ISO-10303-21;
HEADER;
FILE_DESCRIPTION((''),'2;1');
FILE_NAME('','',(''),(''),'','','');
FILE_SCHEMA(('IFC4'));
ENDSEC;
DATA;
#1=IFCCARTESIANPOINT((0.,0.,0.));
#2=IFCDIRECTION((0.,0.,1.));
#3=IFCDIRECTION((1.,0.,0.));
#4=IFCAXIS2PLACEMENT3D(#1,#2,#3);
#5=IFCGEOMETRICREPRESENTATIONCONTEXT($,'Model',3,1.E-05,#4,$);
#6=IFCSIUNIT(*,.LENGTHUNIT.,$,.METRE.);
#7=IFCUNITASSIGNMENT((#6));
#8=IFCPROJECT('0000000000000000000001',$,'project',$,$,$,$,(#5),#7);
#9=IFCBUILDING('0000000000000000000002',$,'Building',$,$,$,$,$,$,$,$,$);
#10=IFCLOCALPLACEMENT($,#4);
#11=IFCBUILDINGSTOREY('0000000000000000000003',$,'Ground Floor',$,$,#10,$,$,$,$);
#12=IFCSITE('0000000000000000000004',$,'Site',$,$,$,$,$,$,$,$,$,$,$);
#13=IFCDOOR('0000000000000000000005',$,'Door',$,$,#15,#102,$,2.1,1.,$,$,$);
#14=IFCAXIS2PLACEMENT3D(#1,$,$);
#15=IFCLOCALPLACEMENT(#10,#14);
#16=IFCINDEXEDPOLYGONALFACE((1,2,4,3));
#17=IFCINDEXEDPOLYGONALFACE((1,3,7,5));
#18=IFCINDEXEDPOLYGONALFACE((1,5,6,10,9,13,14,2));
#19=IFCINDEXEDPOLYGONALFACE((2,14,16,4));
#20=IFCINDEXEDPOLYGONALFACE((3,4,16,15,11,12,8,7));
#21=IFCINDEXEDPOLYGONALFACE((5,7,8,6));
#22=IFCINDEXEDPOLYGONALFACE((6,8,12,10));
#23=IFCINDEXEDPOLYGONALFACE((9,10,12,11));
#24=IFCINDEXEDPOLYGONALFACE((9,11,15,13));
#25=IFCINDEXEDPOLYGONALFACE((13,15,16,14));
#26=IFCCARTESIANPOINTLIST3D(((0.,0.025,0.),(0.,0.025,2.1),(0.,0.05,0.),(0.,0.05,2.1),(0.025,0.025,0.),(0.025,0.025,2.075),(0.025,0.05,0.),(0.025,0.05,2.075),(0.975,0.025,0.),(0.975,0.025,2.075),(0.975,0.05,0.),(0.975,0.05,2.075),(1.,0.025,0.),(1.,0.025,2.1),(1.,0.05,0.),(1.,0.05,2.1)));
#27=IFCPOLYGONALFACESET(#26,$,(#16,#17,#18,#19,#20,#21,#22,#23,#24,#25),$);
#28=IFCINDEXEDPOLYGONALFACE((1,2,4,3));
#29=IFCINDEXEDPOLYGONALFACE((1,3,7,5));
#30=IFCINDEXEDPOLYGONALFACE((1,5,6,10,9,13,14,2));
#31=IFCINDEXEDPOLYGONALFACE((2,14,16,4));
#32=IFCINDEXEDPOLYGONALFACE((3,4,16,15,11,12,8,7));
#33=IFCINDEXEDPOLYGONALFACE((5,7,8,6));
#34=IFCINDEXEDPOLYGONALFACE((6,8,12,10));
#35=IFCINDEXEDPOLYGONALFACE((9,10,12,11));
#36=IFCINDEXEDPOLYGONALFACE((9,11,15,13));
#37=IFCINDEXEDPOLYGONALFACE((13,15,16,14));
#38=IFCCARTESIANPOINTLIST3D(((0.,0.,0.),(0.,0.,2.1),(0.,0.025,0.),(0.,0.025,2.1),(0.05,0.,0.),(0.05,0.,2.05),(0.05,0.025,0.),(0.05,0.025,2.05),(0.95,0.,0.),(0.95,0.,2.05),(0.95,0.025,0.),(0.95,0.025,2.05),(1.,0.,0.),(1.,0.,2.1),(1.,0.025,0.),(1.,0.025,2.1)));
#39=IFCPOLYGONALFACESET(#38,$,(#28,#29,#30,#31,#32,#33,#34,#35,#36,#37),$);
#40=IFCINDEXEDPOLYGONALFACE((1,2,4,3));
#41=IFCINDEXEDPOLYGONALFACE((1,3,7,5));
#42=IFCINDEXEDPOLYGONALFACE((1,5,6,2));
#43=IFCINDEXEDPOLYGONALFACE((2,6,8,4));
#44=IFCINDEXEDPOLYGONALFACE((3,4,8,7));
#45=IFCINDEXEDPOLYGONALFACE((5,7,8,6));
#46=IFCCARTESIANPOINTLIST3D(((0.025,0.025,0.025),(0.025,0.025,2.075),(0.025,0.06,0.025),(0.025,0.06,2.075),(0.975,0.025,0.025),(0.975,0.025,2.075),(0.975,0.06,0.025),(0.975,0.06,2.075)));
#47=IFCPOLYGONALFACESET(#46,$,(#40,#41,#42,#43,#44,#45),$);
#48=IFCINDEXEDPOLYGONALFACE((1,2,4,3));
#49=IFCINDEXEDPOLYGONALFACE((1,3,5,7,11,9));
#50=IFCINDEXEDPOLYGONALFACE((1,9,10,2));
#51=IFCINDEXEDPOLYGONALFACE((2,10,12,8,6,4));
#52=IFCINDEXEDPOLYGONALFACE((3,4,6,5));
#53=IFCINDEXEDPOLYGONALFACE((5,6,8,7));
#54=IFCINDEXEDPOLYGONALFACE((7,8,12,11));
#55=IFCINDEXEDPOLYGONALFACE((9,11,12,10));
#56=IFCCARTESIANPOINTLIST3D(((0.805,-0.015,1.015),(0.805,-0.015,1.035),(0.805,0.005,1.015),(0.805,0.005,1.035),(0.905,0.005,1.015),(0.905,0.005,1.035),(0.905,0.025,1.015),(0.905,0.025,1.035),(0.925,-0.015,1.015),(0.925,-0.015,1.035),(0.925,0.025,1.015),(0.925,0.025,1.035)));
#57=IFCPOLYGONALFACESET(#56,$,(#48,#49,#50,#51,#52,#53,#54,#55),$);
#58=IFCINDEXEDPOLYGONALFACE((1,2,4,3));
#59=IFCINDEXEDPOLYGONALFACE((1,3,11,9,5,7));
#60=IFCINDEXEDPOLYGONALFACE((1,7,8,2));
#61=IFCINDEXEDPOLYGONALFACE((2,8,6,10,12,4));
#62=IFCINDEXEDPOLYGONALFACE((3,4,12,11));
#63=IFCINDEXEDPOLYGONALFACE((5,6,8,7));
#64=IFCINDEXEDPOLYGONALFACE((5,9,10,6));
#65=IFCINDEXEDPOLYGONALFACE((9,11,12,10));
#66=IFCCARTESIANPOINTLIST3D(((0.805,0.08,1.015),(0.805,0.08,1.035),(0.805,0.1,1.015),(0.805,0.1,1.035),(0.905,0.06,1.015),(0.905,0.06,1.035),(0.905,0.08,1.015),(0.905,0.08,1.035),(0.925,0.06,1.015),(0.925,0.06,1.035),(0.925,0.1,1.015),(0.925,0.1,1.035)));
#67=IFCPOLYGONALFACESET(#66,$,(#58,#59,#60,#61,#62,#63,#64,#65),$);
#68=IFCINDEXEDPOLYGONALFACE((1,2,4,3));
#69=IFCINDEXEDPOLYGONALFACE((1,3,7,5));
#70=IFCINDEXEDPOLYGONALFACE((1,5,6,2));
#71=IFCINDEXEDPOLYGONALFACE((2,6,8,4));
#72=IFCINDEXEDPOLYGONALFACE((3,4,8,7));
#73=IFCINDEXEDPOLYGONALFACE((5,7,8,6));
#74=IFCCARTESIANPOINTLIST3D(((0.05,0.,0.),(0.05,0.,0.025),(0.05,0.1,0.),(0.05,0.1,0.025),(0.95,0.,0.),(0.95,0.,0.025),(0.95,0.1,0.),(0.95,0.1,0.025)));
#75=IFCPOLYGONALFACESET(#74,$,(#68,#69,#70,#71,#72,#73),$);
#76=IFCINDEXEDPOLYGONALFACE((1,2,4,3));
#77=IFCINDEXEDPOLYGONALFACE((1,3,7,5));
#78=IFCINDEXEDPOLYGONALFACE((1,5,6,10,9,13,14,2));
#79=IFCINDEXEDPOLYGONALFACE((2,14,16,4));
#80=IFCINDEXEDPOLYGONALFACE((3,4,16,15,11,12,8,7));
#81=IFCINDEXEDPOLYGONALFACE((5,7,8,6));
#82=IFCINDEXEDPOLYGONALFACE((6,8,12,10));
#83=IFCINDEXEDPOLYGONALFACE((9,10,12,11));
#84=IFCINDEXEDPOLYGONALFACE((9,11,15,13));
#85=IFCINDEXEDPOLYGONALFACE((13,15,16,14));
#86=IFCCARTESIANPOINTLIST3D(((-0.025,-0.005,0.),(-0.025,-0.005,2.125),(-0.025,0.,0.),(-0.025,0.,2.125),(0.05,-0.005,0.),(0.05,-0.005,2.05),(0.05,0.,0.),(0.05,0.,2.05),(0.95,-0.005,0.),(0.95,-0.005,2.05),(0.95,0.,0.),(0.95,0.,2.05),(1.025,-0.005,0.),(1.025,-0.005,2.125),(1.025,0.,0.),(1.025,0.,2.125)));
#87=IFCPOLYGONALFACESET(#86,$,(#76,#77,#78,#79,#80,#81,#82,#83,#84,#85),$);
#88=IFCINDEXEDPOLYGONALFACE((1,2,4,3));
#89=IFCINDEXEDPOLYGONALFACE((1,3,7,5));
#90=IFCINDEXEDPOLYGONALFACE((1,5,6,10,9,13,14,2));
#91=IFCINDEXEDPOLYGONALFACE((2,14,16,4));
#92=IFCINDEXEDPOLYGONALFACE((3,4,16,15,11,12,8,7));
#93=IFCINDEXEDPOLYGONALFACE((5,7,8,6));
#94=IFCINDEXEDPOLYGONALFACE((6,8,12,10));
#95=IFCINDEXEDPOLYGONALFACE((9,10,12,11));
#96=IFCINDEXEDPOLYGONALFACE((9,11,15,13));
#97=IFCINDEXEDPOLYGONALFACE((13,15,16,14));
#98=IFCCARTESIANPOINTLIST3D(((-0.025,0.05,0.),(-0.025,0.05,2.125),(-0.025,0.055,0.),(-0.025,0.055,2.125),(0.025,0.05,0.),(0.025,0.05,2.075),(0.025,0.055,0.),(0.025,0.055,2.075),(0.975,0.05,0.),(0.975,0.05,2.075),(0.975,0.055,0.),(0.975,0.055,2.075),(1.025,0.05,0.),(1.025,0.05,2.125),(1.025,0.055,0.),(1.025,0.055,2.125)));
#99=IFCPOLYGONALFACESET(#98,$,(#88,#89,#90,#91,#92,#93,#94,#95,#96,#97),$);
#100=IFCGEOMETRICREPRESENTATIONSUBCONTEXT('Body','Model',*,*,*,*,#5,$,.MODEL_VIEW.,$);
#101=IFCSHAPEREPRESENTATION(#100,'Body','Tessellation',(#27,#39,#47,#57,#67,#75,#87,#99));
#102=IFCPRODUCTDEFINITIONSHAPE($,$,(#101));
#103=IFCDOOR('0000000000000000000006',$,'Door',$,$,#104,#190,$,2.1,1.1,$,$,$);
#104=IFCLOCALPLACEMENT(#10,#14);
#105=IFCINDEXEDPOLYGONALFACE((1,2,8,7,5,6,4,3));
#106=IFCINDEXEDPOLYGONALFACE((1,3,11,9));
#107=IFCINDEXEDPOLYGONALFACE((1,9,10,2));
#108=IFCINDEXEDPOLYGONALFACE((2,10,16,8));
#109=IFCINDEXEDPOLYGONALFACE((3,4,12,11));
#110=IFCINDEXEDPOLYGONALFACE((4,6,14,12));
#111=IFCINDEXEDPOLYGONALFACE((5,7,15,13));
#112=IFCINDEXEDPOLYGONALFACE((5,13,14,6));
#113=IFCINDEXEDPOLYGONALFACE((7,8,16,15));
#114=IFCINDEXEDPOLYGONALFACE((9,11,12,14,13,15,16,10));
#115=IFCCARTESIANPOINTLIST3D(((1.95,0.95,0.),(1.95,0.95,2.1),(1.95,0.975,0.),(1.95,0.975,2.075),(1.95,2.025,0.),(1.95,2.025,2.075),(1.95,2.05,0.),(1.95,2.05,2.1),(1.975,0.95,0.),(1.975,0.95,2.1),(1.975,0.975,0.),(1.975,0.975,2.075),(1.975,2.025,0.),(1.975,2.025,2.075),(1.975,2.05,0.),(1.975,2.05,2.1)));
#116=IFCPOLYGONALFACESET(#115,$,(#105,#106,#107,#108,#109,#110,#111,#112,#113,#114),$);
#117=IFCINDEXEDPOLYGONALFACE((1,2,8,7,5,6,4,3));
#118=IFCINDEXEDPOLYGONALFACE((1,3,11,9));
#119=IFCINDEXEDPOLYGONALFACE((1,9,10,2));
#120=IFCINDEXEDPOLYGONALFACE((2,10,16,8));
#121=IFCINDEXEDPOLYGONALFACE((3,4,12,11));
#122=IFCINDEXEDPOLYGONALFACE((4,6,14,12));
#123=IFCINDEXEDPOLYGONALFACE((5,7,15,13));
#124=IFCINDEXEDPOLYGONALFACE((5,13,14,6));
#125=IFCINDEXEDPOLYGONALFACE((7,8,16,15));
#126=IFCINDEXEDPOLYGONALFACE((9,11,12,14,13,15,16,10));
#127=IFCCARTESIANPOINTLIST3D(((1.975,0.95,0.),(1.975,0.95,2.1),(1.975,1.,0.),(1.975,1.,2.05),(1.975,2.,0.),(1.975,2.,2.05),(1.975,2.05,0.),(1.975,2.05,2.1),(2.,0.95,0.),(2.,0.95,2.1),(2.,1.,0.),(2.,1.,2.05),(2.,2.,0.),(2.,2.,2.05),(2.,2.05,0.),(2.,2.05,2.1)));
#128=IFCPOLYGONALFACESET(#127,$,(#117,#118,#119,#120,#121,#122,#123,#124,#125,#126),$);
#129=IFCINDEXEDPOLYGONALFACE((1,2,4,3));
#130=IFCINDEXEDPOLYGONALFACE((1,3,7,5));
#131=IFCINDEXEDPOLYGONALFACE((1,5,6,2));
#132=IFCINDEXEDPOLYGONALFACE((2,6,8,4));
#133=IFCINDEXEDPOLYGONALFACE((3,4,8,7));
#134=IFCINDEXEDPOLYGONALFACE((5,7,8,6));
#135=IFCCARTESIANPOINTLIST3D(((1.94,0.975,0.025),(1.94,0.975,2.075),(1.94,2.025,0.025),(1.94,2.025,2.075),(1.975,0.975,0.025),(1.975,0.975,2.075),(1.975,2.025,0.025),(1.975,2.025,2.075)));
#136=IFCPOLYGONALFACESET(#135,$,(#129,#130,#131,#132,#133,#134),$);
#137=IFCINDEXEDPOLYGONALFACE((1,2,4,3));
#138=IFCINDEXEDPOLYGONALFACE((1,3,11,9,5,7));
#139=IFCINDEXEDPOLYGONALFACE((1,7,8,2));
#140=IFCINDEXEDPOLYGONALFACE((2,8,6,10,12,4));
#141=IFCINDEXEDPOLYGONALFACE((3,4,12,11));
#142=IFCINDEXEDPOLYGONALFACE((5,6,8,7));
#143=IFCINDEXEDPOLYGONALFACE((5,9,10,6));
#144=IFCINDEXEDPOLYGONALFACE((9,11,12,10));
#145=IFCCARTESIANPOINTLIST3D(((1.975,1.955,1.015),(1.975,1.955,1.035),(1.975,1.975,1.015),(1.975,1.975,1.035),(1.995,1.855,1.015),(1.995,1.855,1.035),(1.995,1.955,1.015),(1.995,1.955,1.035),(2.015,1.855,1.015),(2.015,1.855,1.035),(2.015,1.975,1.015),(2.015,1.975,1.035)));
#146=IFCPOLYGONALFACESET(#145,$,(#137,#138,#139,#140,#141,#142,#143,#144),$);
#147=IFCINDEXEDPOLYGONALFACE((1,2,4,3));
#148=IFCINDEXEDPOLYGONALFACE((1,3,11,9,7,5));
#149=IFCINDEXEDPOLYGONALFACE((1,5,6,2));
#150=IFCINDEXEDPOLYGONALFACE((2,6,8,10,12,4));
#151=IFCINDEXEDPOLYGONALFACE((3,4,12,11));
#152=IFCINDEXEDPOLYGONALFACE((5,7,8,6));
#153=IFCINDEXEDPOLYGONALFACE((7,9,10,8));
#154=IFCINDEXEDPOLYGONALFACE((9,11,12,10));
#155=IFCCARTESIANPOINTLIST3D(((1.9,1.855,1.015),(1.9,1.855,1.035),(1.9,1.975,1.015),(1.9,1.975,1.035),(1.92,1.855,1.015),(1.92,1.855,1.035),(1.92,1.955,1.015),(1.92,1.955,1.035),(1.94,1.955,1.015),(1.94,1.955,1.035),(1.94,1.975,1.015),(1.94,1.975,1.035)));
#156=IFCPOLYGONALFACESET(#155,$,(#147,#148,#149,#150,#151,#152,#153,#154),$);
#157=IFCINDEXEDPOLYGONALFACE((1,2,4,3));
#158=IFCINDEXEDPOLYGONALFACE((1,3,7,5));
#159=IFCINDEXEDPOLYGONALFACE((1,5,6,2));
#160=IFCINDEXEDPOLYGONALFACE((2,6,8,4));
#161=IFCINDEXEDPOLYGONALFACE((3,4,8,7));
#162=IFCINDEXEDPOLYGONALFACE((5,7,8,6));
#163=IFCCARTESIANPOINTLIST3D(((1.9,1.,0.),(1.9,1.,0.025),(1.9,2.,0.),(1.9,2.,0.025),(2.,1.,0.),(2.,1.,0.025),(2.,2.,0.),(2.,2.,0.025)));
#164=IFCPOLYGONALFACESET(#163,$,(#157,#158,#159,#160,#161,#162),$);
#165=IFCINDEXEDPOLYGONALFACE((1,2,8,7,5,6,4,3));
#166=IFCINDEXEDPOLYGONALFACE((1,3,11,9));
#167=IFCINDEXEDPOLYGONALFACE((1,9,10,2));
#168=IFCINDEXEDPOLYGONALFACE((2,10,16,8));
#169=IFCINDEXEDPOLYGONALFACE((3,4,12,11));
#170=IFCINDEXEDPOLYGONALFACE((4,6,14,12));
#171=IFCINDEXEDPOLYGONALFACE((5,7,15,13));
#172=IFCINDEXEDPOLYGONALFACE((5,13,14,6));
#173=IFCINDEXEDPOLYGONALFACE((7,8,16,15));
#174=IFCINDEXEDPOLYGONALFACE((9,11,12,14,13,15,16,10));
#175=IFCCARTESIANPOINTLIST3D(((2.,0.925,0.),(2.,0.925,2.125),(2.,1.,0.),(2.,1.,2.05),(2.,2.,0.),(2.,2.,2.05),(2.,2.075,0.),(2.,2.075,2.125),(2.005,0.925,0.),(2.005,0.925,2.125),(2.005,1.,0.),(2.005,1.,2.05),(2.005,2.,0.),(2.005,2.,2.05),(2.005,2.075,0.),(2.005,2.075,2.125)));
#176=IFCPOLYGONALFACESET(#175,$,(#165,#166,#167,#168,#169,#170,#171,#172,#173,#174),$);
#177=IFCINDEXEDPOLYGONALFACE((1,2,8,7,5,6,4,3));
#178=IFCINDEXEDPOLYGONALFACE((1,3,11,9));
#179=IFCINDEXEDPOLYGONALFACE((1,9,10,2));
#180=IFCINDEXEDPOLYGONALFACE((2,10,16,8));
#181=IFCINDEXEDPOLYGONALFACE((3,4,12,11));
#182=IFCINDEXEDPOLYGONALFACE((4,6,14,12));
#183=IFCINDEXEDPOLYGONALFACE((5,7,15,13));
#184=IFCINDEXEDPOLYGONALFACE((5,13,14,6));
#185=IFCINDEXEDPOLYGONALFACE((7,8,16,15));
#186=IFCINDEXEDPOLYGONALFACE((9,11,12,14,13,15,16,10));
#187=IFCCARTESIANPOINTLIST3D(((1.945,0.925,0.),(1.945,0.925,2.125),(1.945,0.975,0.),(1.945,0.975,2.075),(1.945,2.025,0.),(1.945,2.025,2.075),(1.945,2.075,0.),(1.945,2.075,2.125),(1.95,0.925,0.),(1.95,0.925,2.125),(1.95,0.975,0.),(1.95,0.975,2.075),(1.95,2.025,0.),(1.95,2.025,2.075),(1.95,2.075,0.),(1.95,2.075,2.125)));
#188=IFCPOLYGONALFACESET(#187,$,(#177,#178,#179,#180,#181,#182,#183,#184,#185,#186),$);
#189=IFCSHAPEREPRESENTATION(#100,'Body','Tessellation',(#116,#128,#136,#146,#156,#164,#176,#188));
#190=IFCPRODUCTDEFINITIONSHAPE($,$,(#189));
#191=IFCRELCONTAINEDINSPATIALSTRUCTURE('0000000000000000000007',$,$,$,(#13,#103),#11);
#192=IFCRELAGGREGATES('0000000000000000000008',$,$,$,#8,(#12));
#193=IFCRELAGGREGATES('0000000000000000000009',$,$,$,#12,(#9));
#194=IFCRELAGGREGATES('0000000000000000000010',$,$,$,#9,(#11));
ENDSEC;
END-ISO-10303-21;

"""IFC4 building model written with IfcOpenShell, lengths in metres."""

from ifc_helpers import new_model, si_unit, frame, origin_with_axes, place, context, subcontext, project, spatial, line, indexed_curve, outline, extrude, element, save


model = new_model("IFC4")

# Units and contexts
model_context = context("Model", 3, precision=1e-05, world=origin_with_axes())
body_context = subcontext(model_context, "Body", "Model", "MODEL_VIEW")
ifc_project = project(units=[si_unit("LENGTHUNIT", "METRE")], contexts=[model_context])

# Site, building, storey
site = spatial("IfcSite", under=ifc_project, Name="Site")
building = spatial("IfcBuilding", under=site, Name="Building")
storey_placement = place(None, origin_with_axes())
storey = spatial("IfcBuildingStorey", under=building, at=storey_placement, Name="Ground Floor")

# Doors
door_1_placement = place(storey_placement, origin_with_axes())
element("IfcDoor", 1, at=door_1_placement, inside=storey, Name="Door", OverallHeight=2.1, OverallWidth=1.0, context=body_context, shape_type="SweptSolid", body=[
    extrude(outline(indexed_curve([(0.0, 0.0), (0.0, 2.1), (1.0, 2.1), (1.0, 0.0), (0.975, 0.0), (0.975, 2.075), (0.025, 2.075), (0.025, 0.0)], segments=[line(1, 2, 3, 4, 5, 6, 7, 8, 1)])), frame((0.0, 0.025, 0.0), z_axis=(0.0, -1.0, 0.0), x_axis=(1.0, 0.0, 0.0)), (0.0, 0.0, -1.0), 0.025),
    extrude(outline(indexed_curve([(0.0, 0.0), (0.0, 2.1), (1.0, 2.1), (1.0, 0.0), (0.95, 0.0), (0.95, 2.05), (0.05, 2.05), (0.05, 0.0)], segments=[line(1, 2, 3, 4, 5, 6, 7, 8, 1)])), frame((0.0, 0.0, 0.0), z_axis=(0.0, -1.0, 0.0), x_axis=(1.0, 0.0, 0.0)), (0.0, 0.0, -1.0), 0.025),
    extrude(outline(indexed_curve([(0.0, 0.0), (0.95, 0.0), (0.95, 0.035), (0.0, 0.035)], segments=[line(1, 2, 3, 4, 1)])), frame((0.025, 0.025, 0.025), z_axis=(0.0, 0.0, 1.0), x_axis=(1.0, 0.0, 0.0)), (0.0, 0.0, 1.0), 2.05),
    extrude(outline(indexed_curve([(0.0, 0.0), (0.0, -0.04), (-0.12, -0.04), (-0.12, -0.02), (-0.02, -0.02), (-0.02, 0.0)], segments=[line(1, 2, 3, 4, 5, 6, 1)])), frame((0.925, 0.025, 1.015), z_axis=(0.0, 0.0, 1.0), x_axis=(1.0, 0.0, 0.0)), (0.0, 0.0, 1.0), 0.02),
    extrude(outline(indexed_curve([(0.0, 0.0), (0.0, 0.04), (-0.12, 0.04), (-0.12, 0.02), (-0.02, 0.02), (-0.02, 0.0)], segments=[line(1, 2, 3, 4, 5, 6, 1)])), frame((0.925, 0.06, 1.015), z_axis=(0.0, 0.0, 1.0), x_axis=(1.0, 0.0, 0.0)), (0.0, 0.0, 1.0), 0.02),
    extrude(outline(indexed_curve([(0.0, 0.0), (0.9, 0.0), (0.9, 0.1), (0.0, 0.1)], segments=[line(1, 2, 3, 4, 1)])), frame((0.05, 0.0, 0.0), z_axis=(0.0, 0.0, 1.0), x_axis=(1.0, 0.0, 0.0)), (0.0, 0.0, 1.0), 0.025),
    extrude(outline(indexed_curve([(0.0, 0.0), (0.0, 2.125), (1.05, 2.125), (1.05, 0.0), (0.975, 0.0), (0.975, 2.05), (0.075, 2.05), (0.075, 0.0)], segments=[line(1, 2, 3, 4, 5, 6, 7, 8, 1)])), frame((-0.025, -0.005, 0.0), z_axis=(0.0, -1.0, 0.0), x_axis=(1.0, 0.0, 0.0)), (0.0, 0.0, -1.0), 0.005),
    extrude(outline(indexed_curve([(0.0, 0.0), (0.0, 2.125), (1.05, 2.125), (1.05, 0.0), (1.0, 0.0), (1.0, 2.075), (0.05, 2.075), (0.05, 0.0)], segments=[line(1, 2, 3, 4, 5, 6, 7, 8, 1)])), frame((-0.025, 0.05, 0.0), z_axis=(0.0, -1.0, 0.0), x_axis=(1.0, 0.0, 0.0)), (0.0, 0.0, -1.0), 0.005),
])
door_2_placement = place(storey_placement, frame((2.0, 0.95, 0.0), z_axis=(0.0, 0.0, 1.0), x_axis=(0.0, 1.0, 0.0)))
element("IfcDoor", 2, at=door_2_placement, inside=storey, Name="Door", OverallHeight=2.1, OverallWidth=1.1, context=body_context, shape_type="SweptSolid", body=[
    extrude(outline(indexed_curve([(0.0, 0.0), (0.0, 2.1), (1.1, 2.1), (1.1, 0.0), (1.075, 0.0), (1.075, 2.075), (0.025, 2.075), (0.025, 0.0)], segments=[line(1, 2, 3, 4, 5, 6, 7, 8, 1)])), frame((0.0, 0.025, 0.0), z_axis=(0.0, -1.0, 0.0), x_axis=(1.0, 0.0, 0.0)), (0.0, 0.0, -1.0), 0.025),
    extrude(outline(indexed_curve([(0.0, 0.0), (0.0, 2.1), (1.1, 2.1), (1.1, 0.0), (1.05, 0.0), (1.05, 2.05), (0.05, 2.05), (0.05, 0.0)], segments=[line(1, 2, 3, 4, 5, 6, 7, 8, 1)])), frame((0.0, 0.0, 0.0), z_axis=(0.0, -1.0, 0.0), x_axis=(1.0, 0.0, 0.0)), (0.0, 0.0, -1.0), 0.025),
    extrude(outline(indexed_curve([(0.0, 0.0), (1.05, 0.0), (1.05, 0.035), (0.0, 0.035)], segments=[line(1, 2, 3, 4, 1)])), frame((0.025, 0.025, 0.025), z_axis=(0.0, 0.0, 1.0), x_axis=(1.0, 0.0, 0.0)), (0.0, 0.0, 1.0), 2.05),
    extrude(outline(indexed_curve([(0.0, 0.0), (0.0, -0.04), (-0.12, -0.04), (-0.12, -0.02), (-0.02, -0.02), (-0.02, 0.0)], segments=[line(1, 2, 3, 4, 5, 6, 1)])), frame((1.025, 0.025, 1.015), z_axis=(0.0, 0.0, 1.0), x_axis=(1.0, 0.0, 0.0)), (0.0, 0.0, 1.0), 0.02),
    extrude(outline(indexed_curve([(0.0, 0.0), (0.0, 0.04), (-0.12, 0.04), (-0.12, 0.02), (-0.02, 0.02), (-0.02, 0.0)], segments=[line(1, 2, 3, 4, 5, 6, 1)])), frame((1.025, 0.06, 1.015), z_axis=(0.0, 0.0, 1.0), x_axis=(1.0, 0.0, 0.0)), (0.0, 0.0, 1.0), 0.02),
    extrude(outline(indexed_curve([(0.0, 0.0), (1.0, 0.0), (1.0, 0.1), (0.0, 0.1)], segments=[line(1, 2, 3, 4, 1)])), frame((0.05, 0.0, 0.0), z_axis=(0.0, 0.0, 1.0), x_axis=(1.0, 0.0, 0.0)), (0.0, 0.0, 1.0), 0.025),
    extrude(outline(indexed_curve([(0.0, 0.0), (0.0, 2.125), (1.15, 2.125), (1.15, 0.0), (1.075, 0.0), (1.075, 2.05), (0.075, 2.05), (0.075, 0.0)], segments=[line(1, 2, 3, 4, 5, 6, 7, 8, 1)])), frame((-0.025, -0.005, 0.0), z_axis=(0.0, -1.0, 0.0), x_axis=(1.0, 0.0, 0.0)), (0.0, 0.0, -1.0), 0.005),
    extrude(outline(indexed_curve([(0.0, 0.0), (0.0, 2.125), (1.15, 2.125), (1.15, 0.0), (1.1, 0.0), (1.1, 2.075), (0.05, 2.075), (0.05, 0.0)], segments=[line(1, 2, 3, 4, 5, 6, 7, 8, 1)])), frame((-0.025, 0.05, 0.0), z_axis=(0.0, -1.0, 0.0), x_axis=(1.0, 0.0, 0.0)), (0.0, 0.0, -1.0), 0.005),
])

save(model, "model.ifc")
